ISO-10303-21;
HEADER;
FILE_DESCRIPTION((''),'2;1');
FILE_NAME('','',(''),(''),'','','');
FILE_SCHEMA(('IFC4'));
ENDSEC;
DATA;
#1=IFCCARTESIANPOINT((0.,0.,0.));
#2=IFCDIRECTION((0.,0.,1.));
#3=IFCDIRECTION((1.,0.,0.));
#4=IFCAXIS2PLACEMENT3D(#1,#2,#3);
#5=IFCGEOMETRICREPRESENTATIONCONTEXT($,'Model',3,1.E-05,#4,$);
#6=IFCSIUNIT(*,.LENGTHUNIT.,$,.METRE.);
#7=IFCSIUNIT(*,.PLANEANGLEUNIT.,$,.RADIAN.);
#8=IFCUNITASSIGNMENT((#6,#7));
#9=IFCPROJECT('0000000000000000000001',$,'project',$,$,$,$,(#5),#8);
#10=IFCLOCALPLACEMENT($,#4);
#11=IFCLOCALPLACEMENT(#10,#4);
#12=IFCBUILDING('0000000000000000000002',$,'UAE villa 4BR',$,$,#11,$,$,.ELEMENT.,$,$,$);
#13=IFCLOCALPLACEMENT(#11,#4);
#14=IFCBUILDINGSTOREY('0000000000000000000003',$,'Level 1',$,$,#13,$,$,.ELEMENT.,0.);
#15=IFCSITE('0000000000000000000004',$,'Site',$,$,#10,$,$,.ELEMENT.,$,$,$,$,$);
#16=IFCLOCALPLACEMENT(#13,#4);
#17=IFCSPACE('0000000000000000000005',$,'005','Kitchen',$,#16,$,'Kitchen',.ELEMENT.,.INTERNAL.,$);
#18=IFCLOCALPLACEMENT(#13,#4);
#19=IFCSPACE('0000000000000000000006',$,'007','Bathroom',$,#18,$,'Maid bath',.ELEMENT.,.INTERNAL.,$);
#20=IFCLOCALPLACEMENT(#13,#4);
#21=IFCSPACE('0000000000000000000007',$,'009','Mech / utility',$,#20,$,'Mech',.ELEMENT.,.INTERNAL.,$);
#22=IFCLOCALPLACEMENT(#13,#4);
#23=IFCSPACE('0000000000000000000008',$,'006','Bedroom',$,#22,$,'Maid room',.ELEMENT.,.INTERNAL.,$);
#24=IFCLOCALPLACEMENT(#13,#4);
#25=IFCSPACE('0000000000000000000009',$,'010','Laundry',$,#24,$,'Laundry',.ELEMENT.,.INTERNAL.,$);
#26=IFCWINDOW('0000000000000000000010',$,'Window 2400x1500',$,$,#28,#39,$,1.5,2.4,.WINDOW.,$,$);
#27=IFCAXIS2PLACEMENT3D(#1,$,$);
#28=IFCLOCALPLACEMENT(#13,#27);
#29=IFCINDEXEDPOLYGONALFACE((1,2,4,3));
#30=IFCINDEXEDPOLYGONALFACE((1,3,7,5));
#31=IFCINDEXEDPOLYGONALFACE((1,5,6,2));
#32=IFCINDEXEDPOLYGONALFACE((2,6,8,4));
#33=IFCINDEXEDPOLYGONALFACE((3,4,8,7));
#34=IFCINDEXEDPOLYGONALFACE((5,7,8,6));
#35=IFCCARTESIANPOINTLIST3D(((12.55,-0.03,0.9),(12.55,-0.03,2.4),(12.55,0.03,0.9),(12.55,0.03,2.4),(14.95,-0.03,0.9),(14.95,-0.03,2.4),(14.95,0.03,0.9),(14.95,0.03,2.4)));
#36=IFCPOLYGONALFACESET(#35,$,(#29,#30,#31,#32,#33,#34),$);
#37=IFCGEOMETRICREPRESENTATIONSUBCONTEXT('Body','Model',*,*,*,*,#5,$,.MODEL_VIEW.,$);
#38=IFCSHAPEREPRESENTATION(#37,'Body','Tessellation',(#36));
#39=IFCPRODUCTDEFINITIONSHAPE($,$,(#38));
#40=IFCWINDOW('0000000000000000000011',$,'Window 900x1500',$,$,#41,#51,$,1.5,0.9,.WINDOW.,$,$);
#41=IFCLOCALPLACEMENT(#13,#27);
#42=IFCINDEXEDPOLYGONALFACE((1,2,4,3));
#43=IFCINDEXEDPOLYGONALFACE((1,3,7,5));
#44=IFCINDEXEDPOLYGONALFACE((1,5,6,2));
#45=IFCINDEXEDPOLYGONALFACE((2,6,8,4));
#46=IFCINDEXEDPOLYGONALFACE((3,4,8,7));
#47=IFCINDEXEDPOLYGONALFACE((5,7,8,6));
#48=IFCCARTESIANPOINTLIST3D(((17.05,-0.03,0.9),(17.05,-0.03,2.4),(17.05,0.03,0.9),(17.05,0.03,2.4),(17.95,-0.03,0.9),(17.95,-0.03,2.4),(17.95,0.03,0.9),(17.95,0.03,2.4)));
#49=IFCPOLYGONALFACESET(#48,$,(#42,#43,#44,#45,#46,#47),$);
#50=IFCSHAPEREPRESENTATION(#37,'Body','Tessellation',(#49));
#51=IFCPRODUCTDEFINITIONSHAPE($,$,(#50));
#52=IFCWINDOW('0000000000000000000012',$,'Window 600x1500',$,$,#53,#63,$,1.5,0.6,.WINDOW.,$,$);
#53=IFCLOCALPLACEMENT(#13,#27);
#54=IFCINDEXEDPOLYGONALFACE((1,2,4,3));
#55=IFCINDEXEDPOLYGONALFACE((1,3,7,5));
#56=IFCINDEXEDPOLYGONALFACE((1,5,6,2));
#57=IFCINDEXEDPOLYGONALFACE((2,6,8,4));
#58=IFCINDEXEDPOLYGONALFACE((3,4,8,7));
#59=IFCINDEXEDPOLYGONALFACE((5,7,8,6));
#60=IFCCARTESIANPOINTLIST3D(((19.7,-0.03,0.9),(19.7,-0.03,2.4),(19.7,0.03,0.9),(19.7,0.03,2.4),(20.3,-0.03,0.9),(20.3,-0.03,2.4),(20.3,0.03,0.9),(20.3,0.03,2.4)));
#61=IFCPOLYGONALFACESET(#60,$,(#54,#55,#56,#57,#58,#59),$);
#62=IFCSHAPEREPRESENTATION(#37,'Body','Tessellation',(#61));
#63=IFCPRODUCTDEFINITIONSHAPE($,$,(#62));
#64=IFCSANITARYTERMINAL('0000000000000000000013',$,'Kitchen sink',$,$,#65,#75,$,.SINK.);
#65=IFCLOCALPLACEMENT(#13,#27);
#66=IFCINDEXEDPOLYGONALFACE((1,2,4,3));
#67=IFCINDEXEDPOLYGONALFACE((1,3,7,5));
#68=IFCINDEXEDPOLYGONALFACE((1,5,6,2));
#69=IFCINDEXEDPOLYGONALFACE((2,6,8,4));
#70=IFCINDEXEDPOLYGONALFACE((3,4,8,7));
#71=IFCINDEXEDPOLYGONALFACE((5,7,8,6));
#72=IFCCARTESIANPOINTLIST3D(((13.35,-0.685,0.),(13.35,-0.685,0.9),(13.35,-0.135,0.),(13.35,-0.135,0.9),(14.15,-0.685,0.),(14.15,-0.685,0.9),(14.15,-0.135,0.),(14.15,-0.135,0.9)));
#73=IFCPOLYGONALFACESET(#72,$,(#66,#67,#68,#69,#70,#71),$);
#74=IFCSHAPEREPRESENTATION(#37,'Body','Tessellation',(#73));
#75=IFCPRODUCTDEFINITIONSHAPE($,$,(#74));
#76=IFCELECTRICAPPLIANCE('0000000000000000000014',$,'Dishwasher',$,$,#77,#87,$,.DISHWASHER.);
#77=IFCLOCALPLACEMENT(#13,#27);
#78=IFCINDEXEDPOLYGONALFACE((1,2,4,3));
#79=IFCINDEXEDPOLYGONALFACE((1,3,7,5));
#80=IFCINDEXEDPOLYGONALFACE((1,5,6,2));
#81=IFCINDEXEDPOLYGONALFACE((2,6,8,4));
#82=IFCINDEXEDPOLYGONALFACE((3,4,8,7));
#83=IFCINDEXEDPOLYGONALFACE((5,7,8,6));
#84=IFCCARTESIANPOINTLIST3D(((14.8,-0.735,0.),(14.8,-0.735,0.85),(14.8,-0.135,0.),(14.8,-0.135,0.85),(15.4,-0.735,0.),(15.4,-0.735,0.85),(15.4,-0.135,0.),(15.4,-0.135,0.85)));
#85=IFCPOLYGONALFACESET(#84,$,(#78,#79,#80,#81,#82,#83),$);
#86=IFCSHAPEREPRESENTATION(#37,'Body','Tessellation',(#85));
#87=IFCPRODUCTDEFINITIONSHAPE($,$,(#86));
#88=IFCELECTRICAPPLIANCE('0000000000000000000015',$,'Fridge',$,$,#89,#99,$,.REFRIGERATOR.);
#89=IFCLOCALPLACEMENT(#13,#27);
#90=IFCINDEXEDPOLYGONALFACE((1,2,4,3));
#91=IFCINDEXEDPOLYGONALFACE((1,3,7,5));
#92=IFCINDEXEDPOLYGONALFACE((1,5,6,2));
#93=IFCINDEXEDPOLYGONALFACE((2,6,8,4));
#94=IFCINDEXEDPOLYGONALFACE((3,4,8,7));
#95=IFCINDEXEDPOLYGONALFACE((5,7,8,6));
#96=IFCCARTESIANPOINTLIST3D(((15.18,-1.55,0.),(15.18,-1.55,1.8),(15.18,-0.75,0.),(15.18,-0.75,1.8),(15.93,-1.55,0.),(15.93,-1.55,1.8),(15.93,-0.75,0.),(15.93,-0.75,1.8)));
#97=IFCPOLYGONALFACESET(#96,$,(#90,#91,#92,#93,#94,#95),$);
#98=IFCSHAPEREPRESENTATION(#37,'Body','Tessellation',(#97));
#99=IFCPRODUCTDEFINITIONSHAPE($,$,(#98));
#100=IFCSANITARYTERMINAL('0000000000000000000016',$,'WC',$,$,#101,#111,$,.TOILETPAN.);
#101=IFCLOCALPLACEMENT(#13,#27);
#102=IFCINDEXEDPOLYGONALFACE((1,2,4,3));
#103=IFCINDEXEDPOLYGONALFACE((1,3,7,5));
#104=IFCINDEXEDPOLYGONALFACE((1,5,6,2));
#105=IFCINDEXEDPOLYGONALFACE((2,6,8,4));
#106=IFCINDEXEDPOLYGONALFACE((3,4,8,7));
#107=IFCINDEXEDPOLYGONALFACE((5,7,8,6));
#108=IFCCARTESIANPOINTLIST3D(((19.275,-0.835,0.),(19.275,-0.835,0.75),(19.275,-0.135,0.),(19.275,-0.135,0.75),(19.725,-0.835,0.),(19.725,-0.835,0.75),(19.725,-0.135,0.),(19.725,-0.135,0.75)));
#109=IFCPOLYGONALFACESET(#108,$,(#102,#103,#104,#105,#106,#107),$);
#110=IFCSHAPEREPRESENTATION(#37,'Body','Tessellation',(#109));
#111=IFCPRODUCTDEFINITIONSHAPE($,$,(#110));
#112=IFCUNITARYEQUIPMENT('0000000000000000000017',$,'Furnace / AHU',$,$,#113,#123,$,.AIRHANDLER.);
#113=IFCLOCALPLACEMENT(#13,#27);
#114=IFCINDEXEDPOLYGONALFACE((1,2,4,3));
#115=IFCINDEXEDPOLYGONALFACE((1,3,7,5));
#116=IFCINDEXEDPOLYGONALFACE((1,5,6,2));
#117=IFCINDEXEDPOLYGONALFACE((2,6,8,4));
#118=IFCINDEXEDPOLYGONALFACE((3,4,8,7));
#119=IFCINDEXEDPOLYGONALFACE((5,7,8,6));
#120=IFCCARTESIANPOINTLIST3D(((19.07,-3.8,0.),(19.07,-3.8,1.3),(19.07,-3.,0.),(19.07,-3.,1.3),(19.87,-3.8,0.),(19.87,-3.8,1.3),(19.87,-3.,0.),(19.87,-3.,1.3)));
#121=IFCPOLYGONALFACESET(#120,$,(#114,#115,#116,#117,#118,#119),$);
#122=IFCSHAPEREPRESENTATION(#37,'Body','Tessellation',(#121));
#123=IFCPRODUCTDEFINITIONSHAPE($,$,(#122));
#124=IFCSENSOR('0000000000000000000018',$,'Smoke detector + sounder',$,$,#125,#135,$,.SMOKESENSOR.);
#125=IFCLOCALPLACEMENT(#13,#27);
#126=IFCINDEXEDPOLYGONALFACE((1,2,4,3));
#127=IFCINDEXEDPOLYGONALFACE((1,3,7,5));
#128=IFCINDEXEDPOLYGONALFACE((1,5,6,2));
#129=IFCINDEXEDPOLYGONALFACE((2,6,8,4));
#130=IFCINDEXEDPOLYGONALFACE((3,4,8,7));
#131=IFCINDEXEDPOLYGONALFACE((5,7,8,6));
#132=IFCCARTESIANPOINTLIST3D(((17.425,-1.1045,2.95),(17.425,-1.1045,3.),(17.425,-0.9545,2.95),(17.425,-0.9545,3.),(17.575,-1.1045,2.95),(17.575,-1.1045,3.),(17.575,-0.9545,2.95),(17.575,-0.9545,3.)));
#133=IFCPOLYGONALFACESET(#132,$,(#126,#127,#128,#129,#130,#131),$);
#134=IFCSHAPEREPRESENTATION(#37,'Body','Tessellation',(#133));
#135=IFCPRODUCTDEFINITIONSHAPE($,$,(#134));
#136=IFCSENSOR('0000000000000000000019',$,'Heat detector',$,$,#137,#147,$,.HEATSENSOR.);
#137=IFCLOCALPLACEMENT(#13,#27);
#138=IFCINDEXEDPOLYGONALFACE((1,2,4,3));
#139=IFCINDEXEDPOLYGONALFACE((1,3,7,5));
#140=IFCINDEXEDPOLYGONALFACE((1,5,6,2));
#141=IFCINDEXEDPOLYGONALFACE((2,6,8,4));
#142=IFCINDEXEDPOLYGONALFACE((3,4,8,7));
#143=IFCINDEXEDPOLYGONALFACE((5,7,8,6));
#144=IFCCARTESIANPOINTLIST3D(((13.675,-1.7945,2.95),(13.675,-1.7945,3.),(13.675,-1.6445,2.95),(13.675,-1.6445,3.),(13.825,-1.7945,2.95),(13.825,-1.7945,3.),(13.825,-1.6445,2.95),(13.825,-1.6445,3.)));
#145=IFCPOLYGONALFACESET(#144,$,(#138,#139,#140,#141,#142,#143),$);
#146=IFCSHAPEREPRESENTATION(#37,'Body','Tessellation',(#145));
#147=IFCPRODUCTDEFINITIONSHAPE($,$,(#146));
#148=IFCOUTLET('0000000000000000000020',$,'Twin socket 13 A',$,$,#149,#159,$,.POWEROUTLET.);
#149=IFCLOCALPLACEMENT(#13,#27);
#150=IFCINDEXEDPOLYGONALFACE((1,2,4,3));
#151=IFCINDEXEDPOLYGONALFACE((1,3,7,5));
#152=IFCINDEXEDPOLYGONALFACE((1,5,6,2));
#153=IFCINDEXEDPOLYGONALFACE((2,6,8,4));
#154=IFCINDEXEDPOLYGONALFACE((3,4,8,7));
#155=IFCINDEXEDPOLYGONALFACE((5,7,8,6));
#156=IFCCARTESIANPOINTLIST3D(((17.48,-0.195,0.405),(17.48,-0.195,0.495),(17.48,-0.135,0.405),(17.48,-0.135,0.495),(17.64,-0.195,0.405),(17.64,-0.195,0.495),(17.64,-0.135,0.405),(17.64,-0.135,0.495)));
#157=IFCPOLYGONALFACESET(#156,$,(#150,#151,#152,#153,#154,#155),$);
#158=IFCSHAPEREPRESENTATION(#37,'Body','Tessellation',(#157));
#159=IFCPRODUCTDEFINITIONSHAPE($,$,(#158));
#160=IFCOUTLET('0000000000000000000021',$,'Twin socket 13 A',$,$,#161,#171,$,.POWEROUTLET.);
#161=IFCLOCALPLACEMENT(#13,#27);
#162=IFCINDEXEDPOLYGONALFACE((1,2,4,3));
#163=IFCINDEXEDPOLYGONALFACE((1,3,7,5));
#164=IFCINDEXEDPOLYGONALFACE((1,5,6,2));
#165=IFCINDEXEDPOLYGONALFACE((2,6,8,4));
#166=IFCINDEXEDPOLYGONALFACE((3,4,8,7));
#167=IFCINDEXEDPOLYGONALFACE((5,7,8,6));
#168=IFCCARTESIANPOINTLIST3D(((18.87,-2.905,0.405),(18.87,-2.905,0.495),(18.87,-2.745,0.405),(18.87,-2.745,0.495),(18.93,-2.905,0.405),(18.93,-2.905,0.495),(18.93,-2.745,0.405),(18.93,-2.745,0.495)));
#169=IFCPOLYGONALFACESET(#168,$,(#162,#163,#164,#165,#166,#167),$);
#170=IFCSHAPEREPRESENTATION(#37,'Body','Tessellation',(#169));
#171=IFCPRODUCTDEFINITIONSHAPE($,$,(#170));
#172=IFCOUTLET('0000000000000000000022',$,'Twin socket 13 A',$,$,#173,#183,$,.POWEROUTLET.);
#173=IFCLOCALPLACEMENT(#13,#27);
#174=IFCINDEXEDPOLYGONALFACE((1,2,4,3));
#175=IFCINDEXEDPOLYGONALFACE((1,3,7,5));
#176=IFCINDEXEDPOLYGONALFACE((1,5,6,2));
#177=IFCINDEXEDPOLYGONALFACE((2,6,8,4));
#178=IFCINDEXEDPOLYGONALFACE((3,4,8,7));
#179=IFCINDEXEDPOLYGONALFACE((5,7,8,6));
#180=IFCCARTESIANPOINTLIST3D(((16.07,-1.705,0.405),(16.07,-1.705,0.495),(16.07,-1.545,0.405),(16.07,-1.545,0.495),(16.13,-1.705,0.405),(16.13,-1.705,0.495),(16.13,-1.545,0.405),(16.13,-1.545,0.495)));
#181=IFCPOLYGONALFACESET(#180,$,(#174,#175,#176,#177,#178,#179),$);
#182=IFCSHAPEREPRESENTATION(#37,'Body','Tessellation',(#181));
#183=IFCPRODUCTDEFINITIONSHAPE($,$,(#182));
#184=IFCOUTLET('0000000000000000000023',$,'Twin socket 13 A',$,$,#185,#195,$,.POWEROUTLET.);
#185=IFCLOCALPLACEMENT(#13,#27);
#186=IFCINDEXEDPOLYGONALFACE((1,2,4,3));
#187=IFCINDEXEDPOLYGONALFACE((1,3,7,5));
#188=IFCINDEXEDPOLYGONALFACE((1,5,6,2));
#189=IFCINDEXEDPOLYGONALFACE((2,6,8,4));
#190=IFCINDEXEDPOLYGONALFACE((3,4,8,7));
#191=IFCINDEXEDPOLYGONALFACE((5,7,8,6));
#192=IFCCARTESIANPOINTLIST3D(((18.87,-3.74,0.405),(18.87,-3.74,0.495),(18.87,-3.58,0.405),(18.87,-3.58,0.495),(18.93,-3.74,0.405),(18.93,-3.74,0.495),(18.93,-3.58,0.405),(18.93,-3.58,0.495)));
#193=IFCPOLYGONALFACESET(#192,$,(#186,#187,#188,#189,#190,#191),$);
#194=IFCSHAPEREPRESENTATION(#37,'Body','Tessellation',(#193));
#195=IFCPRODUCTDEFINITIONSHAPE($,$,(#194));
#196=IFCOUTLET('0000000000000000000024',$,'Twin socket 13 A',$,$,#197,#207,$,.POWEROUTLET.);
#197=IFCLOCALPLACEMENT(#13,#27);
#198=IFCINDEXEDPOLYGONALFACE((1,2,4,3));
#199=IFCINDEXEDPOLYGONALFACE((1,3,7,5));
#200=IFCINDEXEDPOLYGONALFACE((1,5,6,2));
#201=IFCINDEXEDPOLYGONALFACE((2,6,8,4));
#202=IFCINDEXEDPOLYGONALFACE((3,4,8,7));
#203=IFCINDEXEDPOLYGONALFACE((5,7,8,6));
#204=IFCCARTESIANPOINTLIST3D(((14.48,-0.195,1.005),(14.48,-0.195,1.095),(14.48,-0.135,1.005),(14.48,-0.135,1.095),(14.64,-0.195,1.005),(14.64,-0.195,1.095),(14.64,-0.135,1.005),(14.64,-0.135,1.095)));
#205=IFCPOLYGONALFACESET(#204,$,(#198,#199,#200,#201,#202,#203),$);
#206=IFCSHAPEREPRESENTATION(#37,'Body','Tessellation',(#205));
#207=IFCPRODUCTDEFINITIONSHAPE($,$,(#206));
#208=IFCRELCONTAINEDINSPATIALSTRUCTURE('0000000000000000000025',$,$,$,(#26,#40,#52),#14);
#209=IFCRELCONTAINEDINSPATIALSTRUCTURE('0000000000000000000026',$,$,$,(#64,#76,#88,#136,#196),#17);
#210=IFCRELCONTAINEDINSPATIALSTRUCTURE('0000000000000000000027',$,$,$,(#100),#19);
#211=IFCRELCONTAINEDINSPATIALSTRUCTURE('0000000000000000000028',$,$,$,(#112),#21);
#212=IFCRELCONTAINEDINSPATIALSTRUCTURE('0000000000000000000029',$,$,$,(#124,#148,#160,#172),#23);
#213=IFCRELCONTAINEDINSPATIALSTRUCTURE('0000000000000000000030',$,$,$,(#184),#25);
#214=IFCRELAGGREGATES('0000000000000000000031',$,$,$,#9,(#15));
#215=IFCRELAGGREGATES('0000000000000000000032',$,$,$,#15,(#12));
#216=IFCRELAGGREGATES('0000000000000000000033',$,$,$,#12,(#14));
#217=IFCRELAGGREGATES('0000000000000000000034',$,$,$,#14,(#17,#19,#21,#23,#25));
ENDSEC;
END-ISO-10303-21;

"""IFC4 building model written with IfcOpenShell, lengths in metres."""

from ifc_helpers import new_model, si_unit, frame, origin, origin_with_axes, origin_2d, place, context, subcontext, project, spatial, rectangle, extrude, element, save


model = new_model("IFC4")

# Units and contexts
model_context = context("Model", 3, precision=1e-05, world=origin_with_axes())
body_context = subcontext(model_context, "Body", "Model", "MODEL_VIEW")
ifc_project = project(units=[si_unit("LENGTHUNIT", "METRE"), si_unit("PLANEANGLEUNIT", "RADIAN")], contexts=[model_context])

# Site, building, storey
site_placement = place(None, origin_with_axes())
site = spatial("IfcSite", under=ifc_project, at=site_placement, Name="Site", CompositionType="ELEMENT")
building_placement = place(site_placement, origin_with_axes())
building = spatial("IfcBuilding", under=site, at=building_placement, Name="UAE villa 4BR", CompositionType="ELEMENT")
storey_placement = place(building_placement, origin_with_axes())
storey = spatial("IfcBuildingStorey", under=building, at=storey_placement, Name="Level 1", CompositionType="ELEMENT", Elevation=0.0)

# Windows
window_1_placement = place(storey_placement, frame((13.75, 0.0, 0.9), z_axis=(0.0, 0.0, 1.0), x_axis=(1.0, 0.0, 0.0)))
element("IfcWindow", 1, at=window_1_placement, inside=storey, Name="Window 2400x1500", OverallHeight=1.5, OverallWidth=2.4, PredefinedType="WINDOW", context=body_context, shape_type="SweptSolid", body=[
    extrude(rectangle(XDim=2.4, YDim=0.06, at=origin_2d()), origin(), (0.0, 0.0, 1.0), 1.5),
])
window_2_placement = place(storey_placement, frame((17.5, 0.0, 0.9), z_axis=(0.0, 0.0, 1.0), x_axis=(1.0, 0.0, 0.0)))
element("IfcWindow", 2, at=window_2_placement, inside=storey, Name="Window 900x1500", OverallHeight=1.5, OverallWidth=0.9, PredefinedType="WINDOW", context=body_context, shape_type="SweptSolid", body=[
    extrude(rectangle(XDim=0.9, YDim=0.06, at=origin_2d()), origin(), (0.0, 0.0, 1.0), 1.5),
])
window_3_placement = place(storey_placement, frame((20.0, 0.0, 0.9), z_axis=(0.0, 0.0, 1.0), x_axis=(1.0, 0.0, 0.0)))
element("IfcWindow", 3, at=window_3_placement, inside=storey, Name="Window 600x1500", OverallHeight=1.5, OverallWidth=0.6, PredefinedType="WINDOW", context=body_context, shape_type="SweptSolid", body=[
    extrude(rectangle(XDim=0.6, YDim=0.06, at=origin_2d()), origin(), (0.0, 0.0, 1.0), 1.5),
])

# Shared definitions
space_1_placement = place(storey_placement, origin_with_axes())
space_1 = spatial("IfcSpace", under=storey, at=space_1_placement, Name="005", Description="Kitchen", LongName="Kitchen", CompositionType="ELEMENT", PredefinedType="INTERNAL")

# Sanitary terminal
sanitary_terminal_1_placement = place(storey_placement, frame((13.75, -0.41, 0.0), z_axis=(0.0, 0.0, 1.0), x_axis=(1.0, 0.0, 0.0)))
element("IfcSanitaryTerminal", 4, at=sanitary_terminal_1_placement, inside=space_1, Name="Kitchen sink", PredefinedType="SINK", context=body_context, shape_type="SweptSolid", body=[
    extrude(rectangle(XDim=0.8, YDim=0.55, at=origin_2d()), origin(), (0.0, 0.0, 1.0), 0.9),
])

# Electric appliances
electric_appliance_1_placement = place(storey_placement, frame((15.1, -0.435, 0.0), z_axis=(0.0, 0.0, 1.0), x_axis=(1.0, 0.0, 0.0)))
element("IfcElectricAppliance", 5, at=electric_appliance_1_placement, inside=space_1, Name="Dishwasher", PredefinedType="DISHWASHER", context=body_context, shape_type="SweptSolid", body=[
    extrude(rectangle(XDim=0.6, YDim=0.6, at=origin_2d()), origin(), (0.0, 0.0, 1.0), 0.85),
])
electric_appliance_2_placement = place(storey_placement, frame((15.555, -1.15, 0.0), z_axis=(0.0, 0.0, 1.0), x_axis=(0.0, -1.0, 0.0)))
element("IfcElectricAppliance", 6, at=electric_appliance_2_placement, inside=space_1, Name="Fridge", PredefinedType="REFRIGERATOR", context=body_context, shape_type="SweptSolid", body=[
    extrude(rectangle(XDim=0.8, YDim=0.75, at=origin_2d()), origin(), (0.0, 0.0, 1.0), 1.8),
])

# Shared definitions
space_2_placement = place(storey_placement, origin_with_axes())
space_2 = spatial("IfcSpace", under=storey, at=space_2_placement, Name="007", Description="Bathroom", LongName="Maid bath", CompositionType="ELEMENT", PredefinedType="INTERNAL")

# Sanitary terminal
sanitary_terminal_2_placement = place(storey_placement, frame((19.5, -0.485, 0.0), z_axis=(0.0, 0.0, 1.0), x_axis=(1.0, 0.0, 0.0)))
element("IfcSanitaryTerminal", 7, at=sanitary_terminal_2_placement, inside=space_2, Name="WC", PredefinedType="TOILETPAN", context=body_context, shape_type="SweptSolid", body=[
    extrude(rectangle(XDim=0.45, YDim=0.7, at=origin_2d()), origin(), (0.0, 0.0, 1.0), 0.75),
])

# Shared definitions
space_3_placement = place(storey_placement, origin_with_axes())
space_3 = spatial("IfcSpace", under=storey, at=space_3_placement, Name="009", Description="Mech / utility", LongName="Mech", CompositionType="ELEMENT", PredefinedType="INTERNAL")

# Unitary equipment
unitary_equipment_placement = place(storey_placement, frame((19.47, -3.4, 0.0), z_axis=(0.0, 0.0, 1.0), x_axis=(0.0, 1.0, 0.0)))
element("IfcUnitaryEquipment", 8, at=unitary_equipment_placement, inside=space_3, Name="Furnace / AHU", PredefinedType="AIRHANDLER", context=body_context, shape_type="SweptSolid", body=[
    extrude(rectangle(XDim=0.8, YDim=0.8, at=origin_2d()), origin(), (0.0, 0.0, 1.0), 1.3),
])

# Shared definitions
space_4_placement = place(storey_placement, origin_with_axes())
space_4 = spatial("IfcSpace", under=storey, at=space_4_placement, Name="006", Description="Bedroom", LongName="Maid room", CompositionType="ELEMENT", PredefinedType="INTERNAL")

# Sensors
sensor_1_placement = place(storey_placement, frame((17.5, -1.0295, 2.95), z_axis=(0.0, 0.0, 1.0), x_axis=(1.0, 0.0, 0.0)))
element("IfcSensor", 9, at=sensor_1_placement, inside=space_4, Name="Smoke detector + sounder", PredefinedType="SMOKESENSOR", context=body_context, shape_type="SweptSolid", body=[
    extrude(rectangle(XDim=0.15, YDim=0.15, at=origin_2d()), origin(), (0.0, 0.0, 1.0), 0.05),
])
sensor_2_placement = place(storey_placement, frame((13.75, -1.7195, 2.95), z_axis=(0.0, 0.0, 1.0), x_axis=(1.0, 0.0, 0.0)))
element("IfcSensor", 10, at=sensor_2_placement, inside=space_1, Name="Heat detector", PredefinedType="HEATSENSOR", context=body_context, shape_type="SweptSolid", body=[
    extrude(rectangle(XDim=0.15, YDim=0.15, at=origin_2d()), origin(), (0.0, 0.0, 1.0), 0.05),
])

# Outlets
for number, where, z_axis, x_axis, name in (
    (11, (17.56, -0.165, 0.405), (0.0, 0.0, 1.0), (1.0, 0.0, 0.0), "Twin socket 13 A"),
    (12, (18.9, -2.825, 0.405), (0.0, 0.0, 1.0), (0.0, -1.0, 0.0), "Twin socket 13 A"),
    (13, (16.1, -1.625, 0.405), (0.0, 0.0, 1.0), (0.0, 1.0, 0.0), "Twin socket 13 A"),
):
    element("IfcOutlet", number, at=place(storey_placement, frame(where, z_axis=z_axis, x_axis=x_axis)), inside=space_4, Name=name, PredefinedType="POWEROUTLET", context=body_context, shape_type="SweptSolid", body=[
        extrude(rectangle(XDim=0.16, YDim=0.06, at=origin_2d()), origin(), (0.0, 0.0, 1.0), 0.09),
    ])

# Shared definitions
space_5_placement = place(storey_placement, origin_with_axes())
space_5 = spatial("IfcSpace", under=storey, at=space_5_placement, Name="010", Description="Laundry", LongName="Laundry", CompositionType="ELEMENT", PredefinedType="INTERNAL")

# Outlets
outlet_placement = place(storey_placement, frame((18.9, -3.66, 0.405), z_axis=(0.0, 0.0, 1.0), x_axis=(0.0, -1.0, 0.0)))
element("IfcOutlet", 14, at=outlet_placement, inside=space_5, Name="Twin socket 13 A", PredefinedType="POWEROUTLET", context=body_context, shape_type="SweptSolid", body=[
    extrude(rectangle(XDim=0.16, YDim=0.06, at=origin_2d()), origin(), (0.0, 0.0, 1.0), 0.09),
])
for number, where, z_axis, x_axis, name in (
    (15, (14.56, -0.165, 1.005), (0.0, 0.0, 1.0), (1.0, 0.0, 0.0), "Twin socket 13 A"),
):
    element("IfcOutlet", number, at=place(storey_placement, frame(where, z_axis=z_axis, x_axis=x_axis)), inside=space_1, Name=name, PredefinedType="POWEROUTLET", context=body_context, shape_type="SweptSolid", body=[
        extrude(rectangle(XDim=0.16, YDim=0.06, at=origin_2d()), origin(), (0.0, 0.0, 1.0), 0.09),
    ])

save(model, "model.ifc")
